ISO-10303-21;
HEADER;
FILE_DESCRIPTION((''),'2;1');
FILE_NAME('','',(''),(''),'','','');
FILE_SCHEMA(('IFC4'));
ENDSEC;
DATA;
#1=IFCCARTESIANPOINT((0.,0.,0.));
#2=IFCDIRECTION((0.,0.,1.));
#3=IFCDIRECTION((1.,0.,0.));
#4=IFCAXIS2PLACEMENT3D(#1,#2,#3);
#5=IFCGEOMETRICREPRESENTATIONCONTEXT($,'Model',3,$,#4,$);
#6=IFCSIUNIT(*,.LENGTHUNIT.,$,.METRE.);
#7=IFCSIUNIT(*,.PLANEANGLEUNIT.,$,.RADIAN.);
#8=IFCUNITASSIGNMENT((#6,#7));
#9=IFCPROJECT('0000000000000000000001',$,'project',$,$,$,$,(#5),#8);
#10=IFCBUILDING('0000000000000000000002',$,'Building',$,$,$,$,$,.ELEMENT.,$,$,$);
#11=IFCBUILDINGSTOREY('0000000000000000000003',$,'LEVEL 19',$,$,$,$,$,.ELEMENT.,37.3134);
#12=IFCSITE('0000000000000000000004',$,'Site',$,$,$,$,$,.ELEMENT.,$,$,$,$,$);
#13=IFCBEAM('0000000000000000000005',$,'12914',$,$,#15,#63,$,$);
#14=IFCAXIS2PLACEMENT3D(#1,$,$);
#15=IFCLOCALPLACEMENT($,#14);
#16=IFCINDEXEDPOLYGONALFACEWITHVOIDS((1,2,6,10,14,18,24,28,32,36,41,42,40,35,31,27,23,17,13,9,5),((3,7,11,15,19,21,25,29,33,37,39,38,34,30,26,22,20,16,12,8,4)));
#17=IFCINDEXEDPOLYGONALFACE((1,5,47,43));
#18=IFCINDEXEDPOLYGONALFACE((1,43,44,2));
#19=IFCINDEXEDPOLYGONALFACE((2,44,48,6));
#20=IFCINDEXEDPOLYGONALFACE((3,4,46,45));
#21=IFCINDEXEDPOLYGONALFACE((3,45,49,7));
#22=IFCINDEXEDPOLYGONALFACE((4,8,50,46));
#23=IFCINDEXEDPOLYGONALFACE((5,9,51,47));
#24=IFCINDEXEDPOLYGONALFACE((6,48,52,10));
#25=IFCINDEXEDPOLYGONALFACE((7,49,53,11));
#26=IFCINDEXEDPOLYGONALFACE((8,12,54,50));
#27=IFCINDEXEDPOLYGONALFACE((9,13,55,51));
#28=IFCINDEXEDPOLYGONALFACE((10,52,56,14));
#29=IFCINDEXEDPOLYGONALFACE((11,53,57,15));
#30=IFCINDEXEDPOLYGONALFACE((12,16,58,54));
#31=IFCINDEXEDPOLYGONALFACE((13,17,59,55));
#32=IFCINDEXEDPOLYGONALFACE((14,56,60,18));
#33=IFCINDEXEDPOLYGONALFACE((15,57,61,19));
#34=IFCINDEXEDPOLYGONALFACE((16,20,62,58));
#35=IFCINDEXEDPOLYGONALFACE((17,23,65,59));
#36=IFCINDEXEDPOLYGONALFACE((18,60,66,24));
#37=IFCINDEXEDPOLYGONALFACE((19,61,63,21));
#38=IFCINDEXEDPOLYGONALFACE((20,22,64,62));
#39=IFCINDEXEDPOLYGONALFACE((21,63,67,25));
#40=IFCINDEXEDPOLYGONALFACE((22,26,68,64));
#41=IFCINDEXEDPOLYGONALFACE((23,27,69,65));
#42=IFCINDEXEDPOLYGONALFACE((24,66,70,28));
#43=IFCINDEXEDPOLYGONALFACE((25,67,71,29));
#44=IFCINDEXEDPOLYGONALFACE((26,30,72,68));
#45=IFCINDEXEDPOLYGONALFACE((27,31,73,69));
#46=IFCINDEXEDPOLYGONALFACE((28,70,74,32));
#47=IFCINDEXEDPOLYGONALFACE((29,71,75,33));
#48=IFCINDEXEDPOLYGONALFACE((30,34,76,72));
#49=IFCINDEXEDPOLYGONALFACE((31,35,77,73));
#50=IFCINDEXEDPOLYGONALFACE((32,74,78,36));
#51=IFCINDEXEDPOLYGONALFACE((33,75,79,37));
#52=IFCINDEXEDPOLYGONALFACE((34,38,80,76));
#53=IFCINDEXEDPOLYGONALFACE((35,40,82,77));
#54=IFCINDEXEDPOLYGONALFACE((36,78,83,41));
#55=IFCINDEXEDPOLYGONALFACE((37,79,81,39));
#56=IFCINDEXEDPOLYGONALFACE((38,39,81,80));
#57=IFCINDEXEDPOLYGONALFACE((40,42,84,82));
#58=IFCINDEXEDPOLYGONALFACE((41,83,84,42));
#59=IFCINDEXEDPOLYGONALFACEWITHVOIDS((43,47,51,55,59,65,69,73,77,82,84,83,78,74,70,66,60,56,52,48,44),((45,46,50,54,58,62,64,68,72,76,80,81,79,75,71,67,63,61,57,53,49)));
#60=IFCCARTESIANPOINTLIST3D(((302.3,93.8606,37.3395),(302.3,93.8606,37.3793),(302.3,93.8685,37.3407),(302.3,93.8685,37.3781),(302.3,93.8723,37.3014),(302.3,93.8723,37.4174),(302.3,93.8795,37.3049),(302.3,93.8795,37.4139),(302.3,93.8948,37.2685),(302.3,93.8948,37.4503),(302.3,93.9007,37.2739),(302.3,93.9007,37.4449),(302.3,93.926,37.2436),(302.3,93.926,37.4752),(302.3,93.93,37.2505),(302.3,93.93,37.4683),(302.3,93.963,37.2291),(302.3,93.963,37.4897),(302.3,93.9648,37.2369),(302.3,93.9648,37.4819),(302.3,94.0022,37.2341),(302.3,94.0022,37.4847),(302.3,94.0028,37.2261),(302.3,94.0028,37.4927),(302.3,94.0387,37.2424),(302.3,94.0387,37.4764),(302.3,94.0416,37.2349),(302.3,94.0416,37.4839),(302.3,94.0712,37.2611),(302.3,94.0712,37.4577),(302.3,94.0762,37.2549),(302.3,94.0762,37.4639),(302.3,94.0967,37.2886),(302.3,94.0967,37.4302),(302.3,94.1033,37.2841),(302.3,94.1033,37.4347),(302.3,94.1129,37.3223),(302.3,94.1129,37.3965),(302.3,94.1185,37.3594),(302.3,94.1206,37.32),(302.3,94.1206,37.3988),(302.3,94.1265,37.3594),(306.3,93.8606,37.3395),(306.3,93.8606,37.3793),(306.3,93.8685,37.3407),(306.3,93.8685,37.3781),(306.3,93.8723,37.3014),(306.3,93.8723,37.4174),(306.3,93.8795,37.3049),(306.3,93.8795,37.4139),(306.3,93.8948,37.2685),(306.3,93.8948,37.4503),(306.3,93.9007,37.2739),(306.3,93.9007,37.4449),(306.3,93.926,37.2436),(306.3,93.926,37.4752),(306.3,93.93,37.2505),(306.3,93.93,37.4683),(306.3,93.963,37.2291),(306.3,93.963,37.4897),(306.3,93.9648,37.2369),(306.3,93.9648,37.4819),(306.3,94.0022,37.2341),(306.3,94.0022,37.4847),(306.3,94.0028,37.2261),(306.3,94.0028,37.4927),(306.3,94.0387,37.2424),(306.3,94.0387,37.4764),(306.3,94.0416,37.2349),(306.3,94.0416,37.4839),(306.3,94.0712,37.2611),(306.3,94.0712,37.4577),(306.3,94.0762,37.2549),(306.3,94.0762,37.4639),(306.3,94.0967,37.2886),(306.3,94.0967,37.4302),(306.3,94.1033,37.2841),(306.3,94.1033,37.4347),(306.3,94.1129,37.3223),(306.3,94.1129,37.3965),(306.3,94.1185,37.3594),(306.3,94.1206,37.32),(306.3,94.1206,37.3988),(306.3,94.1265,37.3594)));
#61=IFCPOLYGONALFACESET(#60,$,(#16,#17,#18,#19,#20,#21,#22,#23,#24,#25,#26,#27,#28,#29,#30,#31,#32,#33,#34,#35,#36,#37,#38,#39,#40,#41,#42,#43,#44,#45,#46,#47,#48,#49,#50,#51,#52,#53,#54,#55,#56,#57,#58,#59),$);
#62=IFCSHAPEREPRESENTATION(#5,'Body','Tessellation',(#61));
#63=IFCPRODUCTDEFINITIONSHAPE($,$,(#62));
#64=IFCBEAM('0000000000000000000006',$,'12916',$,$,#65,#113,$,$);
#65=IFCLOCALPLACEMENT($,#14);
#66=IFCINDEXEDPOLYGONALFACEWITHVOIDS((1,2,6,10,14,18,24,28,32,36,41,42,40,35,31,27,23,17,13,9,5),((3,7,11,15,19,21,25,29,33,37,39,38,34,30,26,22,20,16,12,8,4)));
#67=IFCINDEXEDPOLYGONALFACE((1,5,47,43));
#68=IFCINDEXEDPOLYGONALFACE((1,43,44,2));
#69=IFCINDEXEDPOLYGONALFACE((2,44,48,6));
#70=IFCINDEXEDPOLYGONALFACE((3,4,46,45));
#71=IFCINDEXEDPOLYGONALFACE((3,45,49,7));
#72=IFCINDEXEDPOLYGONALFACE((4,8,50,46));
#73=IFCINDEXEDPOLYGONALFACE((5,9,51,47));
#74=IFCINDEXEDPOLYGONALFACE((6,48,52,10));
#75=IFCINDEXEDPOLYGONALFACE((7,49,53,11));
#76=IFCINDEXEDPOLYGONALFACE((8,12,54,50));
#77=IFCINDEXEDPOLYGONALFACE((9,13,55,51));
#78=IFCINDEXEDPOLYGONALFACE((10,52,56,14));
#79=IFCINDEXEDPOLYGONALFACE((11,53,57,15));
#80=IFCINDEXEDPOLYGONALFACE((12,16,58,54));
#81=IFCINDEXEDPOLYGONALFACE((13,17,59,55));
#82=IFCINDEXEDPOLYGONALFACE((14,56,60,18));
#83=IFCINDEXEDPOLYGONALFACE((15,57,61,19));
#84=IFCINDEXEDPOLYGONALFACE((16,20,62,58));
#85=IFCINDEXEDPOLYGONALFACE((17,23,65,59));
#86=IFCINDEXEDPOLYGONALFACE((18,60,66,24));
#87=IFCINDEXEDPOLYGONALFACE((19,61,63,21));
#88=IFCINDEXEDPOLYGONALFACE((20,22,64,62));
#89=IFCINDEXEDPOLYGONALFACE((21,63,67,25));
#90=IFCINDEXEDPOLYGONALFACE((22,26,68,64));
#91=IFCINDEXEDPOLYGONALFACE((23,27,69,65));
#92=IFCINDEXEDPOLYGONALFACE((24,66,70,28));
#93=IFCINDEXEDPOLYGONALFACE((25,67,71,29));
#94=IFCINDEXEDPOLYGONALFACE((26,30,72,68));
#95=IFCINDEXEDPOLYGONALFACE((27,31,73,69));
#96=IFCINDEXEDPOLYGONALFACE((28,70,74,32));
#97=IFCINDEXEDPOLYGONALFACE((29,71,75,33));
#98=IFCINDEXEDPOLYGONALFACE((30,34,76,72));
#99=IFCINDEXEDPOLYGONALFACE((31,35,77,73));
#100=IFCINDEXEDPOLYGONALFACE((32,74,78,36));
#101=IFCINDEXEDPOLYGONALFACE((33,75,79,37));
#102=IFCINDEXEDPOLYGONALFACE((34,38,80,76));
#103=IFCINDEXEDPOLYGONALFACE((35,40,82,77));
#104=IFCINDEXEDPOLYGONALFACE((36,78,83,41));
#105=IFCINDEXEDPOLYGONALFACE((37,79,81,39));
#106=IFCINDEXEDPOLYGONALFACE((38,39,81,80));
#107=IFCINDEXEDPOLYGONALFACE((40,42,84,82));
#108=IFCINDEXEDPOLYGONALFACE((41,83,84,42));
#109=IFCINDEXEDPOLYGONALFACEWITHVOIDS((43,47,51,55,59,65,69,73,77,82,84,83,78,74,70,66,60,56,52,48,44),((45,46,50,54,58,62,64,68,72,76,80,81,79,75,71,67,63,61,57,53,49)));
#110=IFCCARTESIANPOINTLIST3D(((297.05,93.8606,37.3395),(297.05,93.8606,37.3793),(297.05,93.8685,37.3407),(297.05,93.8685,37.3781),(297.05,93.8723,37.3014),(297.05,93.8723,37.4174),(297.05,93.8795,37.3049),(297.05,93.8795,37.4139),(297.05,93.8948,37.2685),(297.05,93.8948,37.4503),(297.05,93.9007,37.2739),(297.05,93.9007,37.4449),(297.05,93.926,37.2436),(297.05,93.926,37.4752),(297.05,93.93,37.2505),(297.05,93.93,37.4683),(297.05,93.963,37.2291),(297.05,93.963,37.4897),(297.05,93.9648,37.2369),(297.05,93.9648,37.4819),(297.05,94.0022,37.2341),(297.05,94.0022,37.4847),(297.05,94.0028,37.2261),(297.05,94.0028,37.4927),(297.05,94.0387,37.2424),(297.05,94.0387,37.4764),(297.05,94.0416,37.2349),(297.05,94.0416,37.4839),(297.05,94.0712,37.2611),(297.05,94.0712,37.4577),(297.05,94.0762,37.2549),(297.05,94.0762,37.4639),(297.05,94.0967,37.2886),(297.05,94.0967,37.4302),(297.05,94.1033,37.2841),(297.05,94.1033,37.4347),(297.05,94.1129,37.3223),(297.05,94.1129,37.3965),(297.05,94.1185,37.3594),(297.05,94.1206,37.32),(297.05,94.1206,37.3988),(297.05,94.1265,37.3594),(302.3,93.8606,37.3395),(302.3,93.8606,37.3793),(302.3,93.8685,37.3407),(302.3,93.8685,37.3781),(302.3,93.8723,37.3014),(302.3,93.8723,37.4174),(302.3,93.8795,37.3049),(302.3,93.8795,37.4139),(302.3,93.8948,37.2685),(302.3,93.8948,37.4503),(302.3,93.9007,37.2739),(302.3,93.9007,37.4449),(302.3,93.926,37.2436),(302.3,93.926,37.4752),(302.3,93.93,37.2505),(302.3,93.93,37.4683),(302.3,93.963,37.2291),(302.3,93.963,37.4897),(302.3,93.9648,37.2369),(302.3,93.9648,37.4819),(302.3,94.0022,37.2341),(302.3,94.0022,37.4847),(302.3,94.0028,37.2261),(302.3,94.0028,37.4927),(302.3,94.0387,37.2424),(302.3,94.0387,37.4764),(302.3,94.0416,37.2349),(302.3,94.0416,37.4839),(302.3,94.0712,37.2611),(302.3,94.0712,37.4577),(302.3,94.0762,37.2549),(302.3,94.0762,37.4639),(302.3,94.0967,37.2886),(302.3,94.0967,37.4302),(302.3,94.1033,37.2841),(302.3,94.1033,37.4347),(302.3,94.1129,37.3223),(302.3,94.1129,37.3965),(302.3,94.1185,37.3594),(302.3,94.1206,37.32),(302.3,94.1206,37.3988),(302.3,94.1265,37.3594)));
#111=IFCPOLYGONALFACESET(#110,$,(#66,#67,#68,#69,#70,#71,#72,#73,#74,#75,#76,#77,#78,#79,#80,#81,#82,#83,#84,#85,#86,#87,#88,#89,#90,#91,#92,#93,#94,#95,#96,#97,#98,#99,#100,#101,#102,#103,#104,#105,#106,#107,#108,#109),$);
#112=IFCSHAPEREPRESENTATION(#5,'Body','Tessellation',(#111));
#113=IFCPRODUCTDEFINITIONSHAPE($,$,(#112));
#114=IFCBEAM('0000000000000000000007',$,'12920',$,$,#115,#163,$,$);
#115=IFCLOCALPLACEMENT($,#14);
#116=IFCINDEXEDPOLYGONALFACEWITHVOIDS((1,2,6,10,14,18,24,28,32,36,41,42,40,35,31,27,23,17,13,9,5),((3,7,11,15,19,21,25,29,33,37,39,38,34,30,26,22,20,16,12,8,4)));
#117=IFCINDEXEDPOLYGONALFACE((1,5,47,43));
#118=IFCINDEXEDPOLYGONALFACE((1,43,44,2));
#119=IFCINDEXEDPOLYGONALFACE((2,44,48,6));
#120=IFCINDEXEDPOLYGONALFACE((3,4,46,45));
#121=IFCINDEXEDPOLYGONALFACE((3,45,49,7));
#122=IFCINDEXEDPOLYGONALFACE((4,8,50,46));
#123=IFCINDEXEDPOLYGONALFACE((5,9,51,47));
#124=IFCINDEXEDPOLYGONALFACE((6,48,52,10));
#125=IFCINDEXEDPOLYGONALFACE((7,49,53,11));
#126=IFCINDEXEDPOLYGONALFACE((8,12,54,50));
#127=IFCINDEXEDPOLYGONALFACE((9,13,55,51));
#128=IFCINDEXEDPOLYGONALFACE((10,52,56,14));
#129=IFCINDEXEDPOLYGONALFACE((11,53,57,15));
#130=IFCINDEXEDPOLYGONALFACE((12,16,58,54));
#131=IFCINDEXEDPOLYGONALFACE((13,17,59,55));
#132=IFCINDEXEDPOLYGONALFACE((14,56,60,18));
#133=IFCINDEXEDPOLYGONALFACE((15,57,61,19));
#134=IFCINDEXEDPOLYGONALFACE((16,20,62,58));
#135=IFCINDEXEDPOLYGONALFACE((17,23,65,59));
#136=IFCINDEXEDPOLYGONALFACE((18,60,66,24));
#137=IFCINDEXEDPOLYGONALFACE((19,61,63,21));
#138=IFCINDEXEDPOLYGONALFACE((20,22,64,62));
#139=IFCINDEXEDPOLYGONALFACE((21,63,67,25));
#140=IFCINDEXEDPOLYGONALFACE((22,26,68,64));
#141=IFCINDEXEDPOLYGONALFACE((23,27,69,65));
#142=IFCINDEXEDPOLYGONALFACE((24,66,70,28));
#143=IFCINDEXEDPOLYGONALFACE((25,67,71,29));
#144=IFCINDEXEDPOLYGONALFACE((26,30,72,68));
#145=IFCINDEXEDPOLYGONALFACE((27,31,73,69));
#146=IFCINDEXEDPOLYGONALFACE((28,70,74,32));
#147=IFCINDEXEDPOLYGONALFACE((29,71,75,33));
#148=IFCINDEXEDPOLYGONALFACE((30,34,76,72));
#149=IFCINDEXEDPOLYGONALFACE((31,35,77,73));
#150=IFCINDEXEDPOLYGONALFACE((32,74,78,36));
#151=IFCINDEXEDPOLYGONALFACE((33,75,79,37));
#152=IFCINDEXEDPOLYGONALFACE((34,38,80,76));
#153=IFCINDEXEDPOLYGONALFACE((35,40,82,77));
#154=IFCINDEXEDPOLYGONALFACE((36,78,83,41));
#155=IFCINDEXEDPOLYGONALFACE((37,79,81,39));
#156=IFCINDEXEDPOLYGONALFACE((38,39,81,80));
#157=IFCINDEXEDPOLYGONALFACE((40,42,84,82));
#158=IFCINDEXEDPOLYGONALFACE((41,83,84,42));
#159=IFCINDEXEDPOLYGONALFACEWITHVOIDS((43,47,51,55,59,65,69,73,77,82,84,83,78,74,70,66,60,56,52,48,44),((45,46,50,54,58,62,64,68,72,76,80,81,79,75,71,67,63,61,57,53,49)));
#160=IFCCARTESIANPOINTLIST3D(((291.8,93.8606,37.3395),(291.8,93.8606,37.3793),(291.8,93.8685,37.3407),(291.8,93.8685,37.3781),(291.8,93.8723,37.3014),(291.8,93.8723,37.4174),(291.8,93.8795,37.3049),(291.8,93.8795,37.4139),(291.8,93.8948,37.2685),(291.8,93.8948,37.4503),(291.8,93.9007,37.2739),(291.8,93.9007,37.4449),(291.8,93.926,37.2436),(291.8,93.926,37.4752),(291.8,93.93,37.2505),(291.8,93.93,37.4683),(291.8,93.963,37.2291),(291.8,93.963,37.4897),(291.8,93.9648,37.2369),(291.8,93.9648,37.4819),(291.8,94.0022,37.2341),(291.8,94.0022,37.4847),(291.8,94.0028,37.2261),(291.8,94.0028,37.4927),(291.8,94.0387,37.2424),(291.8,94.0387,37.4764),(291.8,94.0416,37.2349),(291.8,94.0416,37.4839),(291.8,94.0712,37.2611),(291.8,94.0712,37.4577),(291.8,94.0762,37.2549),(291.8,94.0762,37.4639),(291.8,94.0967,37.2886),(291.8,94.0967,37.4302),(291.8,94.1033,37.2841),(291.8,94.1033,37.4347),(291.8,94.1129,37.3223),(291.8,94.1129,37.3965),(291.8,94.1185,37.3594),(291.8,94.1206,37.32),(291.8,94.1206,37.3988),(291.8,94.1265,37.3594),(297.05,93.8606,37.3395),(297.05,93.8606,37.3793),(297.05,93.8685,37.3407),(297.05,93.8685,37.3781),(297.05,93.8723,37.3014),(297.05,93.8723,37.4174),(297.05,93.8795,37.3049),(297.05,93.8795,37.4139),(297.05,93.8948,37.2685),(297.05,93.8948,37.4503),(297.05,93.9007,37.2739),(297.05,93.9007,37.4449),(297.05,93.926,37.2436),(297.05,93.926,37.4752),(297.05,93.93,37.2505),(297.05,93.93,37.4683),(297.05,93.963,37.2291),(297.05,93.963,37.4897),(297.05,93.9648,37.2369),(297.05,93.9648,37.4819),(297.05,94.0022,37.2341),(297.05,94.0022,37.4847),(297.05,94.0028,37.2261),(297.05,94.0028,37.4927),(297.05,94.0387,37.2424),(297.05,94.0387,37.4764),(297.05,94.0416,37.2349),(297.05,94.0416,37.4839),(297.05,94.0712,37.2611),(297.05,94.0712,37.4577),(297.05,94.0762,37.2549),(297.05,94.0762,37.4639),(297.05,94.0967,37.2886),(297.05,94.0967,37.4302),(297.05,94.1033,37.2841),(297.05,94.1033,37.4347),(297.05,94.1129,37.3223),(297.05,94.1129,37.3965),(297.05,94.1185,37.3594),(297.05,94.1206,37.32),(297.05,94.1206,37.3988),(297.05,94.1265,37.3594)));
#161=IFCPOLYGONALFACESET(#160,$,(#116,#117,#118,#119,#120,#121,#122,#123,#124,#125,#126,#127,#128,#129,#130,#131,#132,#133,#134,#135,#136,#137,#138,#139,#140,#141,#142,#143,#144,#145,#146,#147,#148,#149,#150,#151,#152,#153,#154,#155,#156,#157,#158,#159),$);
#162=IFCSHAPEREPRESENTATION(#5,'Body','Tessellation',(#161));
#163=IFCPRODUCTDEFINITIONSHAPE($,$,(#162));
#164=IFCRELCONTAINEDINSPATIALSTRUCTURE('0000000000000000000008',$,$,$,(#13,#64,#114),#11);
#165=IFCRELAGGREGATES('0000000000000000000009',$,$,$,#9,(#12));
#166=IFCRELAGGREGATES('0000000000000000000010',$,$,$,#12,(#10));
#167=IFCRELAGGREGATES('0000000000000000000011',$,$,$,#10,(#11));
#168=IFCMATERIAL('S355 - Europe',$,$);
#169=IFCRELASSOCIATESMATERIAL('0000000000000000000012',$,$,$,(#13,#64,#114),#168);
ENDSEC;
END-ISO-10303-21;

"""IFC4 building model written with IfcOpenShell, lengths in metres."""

from ifc_helpers import new_model, si_unit, frame, origin_with_axes, origin_2d_with_axis, place, context, project, spatial, hollow_circle, extrude, material, material_profile, profile_set, profile_usage, element, save


model = new_model("IFC4")

# Units and contexts
model_context = context("Model", 3, world=origin_with_axes())
ifc_project = project(units=[si_unit("LENGTHUNIT", "METRE"), si_unit("PLANEANGLEUNIT", "RADIAN")], contexts=[model_context])

# Site, building, storey
site = spatial("IfcSite", under=ifc_project, Name="Site", CompositionType="ELEMENT")
building = spatial("IfcBuilding", under=site, Name="Building", CompositionType="ELEMENT")
storey = spatial("IfcBuildingStorey", under=building, Name="LEVEL 19", CompositionType="ELEMENT", Elevation=37.3134)

# Beams
ifc_material = material(Name="S355 - Europe")
ifc_material_profile_1 = material_profile(ifc_material, hollow_circle(Radius=0.1337, WallThickness=0.008, at=origin_2d_with_axis()))
ifc_profile_set_1 = profile_set([ifc_material_profile_1])
ifc_profile_usage_1 = profile_usage(ifc_profile_set_1, cardinal=10)
beam_1_placement = place(None, frame((302.3, 93.9928, 37.3594), z_axis=(1.0, 0.0, 0.0), x_axis=(0.0, 1.0, 0.0)))
element("IfcBeam", 1, at=beam_1_placement, inside=storey, material=ifc_profile_usage_1, Name="12914", context=model_context, shape_type="SweptSolid", body=[
    extrude(hollow_circle(Radius=0.1337, WallThickness=0.008, at=origin_2d_with_axis()), origin_with_axes(), (0.0, 0.0, 1.0), 4.0),
])
ifc_material_profile_2 = material_profile(ifc_material, hollow_circle(Radius=0.1337, WallThickness=0.008, at=origin_2d_with_axis()))
ifc_profile_set_2 = profile_set([ifc_material_profile_2])
ifc_profile_usage_2 = profile_usage(ifc_profile_set_2, cardinal=10)
beam_2_placement = place(None, frame((297.05, 93.9928, 37.3594), z_axis=(1.0, 0.0, 0.0), x_axis=(0.0, 1.0, 0.0)))
element("IfcBeam", 2, at=beam_2_placement, inside=storey, material=ifc_profile_usage_2, Name="12916", context=model_context, shape_type="SweptSolid", body=[
    extrude(hollow_circle(Radius=0.1337, WallThickness=0.008, at=origin_2d_with_axis()), origin_with_axes(), (0.0, 0.0, 1.0), 5.25),
])
ifc_material_profile_3 = material_profile(ifc_material, hollow_circle(Radius=0.1337, WallThickness=0.008, at=origin_2d_with_axis()))
ifc_profile_set_3 = profile_set([ifc_material_profile_3])
ifc_profile_usage_3 = profile_usage(ifc_profile_set_3, cardinal=10)
beam_3_placement = place(None, frame((291.8, 93.9928, 37.3594), z_axis=(1.0, 0.0, 0.0), x_axis=(0.0, 1.0, 0.0)))
element("IfcBeam", 3, at=beam_3_placement, inside=storey, material=ifc_profile_usage_3, Name="12920", context=model_context, shape_type="SweptSolid", body=[
    extrude(hollow_circle(Radius=0.1337, WallThickness=0.008, at=origin_2d_with_axis()), origin_with_axes(), (0.0, 0.0, 1.0), 5.25),
])

save(model, "model.ifc")
